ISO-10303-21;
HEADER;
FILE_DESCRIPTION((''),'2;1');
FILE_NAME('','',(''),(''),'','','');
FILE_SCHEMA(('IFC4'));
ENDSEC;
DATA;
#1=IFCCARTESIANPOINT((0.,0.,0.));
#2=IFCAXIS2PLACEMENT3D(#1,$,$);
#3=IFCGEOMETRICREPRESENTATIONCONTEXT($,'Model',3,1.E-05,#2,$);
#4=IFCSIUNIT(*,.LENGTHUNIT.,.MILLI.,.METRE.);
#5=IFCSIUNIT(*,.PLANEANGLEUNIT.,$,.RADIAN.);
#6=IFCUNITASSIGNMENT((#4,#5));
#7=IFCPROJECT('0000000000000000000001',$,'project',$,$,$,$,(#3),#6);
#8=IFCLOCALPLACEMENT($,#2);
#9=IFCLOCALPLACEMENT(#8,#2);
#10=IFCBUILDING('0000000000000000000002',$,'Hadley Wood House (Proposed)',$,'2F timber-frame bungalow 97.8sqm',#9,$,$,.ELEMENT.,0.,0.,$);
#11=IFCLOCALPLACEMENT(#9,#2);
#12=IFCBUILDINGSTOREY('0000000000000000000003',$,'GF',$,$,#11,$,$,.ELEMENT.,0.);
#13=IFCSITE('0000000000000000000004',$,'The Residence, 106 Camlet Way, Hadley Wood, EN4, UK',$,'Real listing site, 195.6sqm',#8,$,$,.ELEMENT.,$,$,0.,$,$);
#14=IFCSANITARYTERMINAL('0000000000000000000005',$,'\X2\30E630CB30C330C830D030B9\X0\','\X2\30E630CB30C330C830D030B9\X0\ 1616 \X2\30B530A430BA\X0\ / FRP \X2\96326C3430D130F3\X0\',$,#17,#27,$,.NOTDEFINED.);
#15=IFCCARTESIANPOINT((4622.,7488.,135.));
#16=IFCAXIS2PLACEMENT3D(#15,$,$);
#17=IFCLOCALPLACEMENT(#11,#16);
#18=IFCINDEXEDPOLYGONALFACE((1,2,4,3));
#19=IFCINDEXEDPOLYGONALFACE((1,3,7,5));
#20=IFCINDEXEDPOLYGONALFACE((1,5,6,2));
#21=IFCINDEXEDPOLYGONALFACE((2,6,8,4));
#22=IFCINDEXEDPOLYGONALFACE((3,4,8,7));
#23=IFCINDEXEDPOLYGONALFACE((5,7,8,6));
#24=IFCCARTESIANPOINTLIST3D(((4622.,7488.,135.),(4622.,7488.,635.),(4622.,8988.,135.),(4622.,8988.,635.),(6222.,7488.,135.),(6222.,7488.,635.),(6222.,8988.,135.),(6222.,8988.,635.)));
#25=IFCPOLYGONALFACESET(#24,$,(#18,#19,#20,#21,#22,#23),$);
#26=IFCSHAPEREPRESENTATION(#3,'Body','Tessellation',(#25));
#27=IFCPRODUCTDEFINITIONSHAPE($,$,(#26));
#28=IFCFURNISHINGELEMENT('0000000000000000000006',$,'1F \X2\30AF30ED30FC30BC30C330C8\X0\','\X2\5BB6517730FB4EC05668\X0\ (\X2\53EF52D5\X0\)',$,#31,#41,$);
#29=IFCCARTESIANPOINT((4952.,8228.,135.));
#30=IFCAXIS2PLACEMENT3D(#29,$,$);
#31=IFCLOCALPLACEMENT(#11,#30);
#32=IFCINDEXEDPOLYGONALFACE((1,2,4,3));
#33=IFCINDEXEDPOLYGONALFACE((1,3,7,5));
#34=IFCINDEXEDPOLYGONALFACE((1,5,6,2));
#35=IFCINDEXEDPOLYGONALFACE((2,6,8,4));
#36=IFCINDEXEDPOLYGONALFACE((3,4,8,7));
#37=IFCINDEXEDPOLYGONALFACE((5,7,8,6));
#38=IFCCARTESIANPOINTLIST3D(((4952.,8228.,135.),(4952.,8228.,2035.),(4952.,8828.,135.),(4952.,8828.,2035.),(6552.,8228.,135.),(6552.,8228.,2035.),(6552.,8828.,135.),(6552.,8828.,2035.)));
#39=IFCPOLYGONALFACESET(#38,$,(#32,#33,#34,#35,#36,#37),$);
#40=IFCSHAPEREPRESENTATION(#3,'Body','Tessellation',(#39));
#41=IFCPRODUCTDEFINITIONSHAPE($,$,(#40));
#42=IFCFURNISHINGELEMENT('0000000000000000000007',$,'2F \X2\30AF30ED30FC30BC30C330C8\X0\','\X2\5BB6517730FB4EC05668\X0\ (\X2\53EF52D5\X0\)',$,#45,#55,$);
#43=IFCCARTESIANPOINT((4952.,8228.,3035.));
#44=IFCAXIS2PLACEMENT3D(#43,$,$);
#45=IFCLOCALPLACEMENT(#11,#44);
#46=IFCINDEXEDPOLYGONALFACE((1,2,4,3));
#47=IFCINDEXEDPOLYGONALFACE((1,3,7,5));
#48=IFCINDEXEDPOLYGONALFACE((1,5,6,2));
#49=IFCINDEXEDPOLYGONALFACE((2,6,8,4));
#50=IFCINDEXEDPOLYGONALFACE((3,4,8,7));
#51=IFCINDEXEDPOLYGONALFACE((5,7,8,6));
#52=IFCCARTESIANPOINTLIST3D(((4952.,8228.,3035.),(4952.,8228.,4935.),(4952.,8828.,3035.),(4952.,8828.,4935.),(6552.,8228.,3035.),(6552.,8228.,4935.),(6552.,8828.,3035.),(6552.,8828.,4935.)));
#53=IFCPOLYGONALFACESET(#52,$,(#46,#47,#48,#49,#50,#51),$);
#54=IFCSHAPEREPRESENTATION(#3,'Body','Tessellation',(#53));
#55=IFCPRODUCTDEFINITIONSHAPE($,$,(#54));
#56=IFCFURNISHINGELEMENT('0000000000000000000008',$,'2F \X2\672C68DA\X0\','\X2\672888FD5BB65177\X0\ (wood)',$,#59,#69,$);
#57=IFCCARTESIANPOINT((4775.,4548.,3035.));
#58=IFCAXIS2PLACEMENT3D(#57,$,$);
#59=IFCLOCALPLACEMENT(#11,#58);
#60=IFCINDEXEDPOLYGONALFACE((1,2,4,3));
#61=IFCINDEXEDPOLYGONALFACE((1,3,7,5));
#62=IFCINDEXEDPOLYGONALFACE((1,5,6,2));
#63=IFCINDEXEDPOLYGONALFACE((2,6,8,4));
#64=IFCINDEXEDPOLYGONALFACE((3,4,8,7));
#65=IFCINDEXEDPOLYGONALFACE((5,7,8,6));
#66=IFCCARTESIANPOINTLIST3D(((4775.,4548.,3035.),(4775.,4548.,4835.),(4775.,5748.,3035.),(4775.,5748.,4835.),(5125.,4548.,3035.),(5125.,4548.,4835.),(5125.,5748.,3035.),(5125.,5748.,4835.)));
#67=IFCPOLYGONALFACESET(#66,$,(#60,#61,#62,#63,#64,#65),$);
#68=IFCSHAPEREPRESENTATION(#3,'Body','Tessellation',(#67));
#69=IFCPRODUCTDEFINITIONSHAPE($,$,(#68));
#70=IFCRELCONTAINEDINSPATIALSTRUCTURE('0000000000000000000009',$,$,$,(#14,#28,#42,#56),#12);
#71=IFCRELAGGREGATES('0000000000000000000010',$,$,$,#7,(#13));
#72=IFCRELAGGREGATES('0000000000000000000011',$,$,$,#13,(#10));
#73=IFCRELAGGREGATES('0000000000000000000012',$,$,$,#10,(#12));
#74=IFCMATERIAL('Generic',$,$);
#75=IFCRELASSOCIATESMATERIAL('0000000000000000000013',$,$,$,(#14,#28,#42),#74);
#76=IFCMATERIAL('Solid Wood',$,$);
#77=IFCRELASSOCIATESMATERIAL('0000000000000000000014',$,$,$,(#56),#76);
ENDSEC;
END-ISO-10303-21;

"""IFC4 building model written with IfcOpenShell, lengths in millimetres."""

from ifc_helpers import new_model, si_unit, frame, frame_2d, origin, place, context, project, spatial, rectangle, extrude, material, element, save


model = new_model("IFC4")

# Units and contexts
model_context = context("Model", 3, precision=1e-05, world=origin())
ifc_project = project(units=[si_unit("LENGTHUNIT", "METRE", prefix="MILLI"), si_unit("PLANEANGLEUNIT", "RADIAN")], contexts=[model_context])

# Site, building, storey
site_placement = place(None, origin())
site = spatial("IfcSite", under=ifc_project, at=site_placement, Name="The Residence, 106 Camlet Way, Hadley Wood, EN4, UK", ObjectType="Real listing site, 195.6sqm", CompositionType="ELEMENT", RefElevation=0.0)
building_placement = place(site_placement, origin())
building = spatial("IfcBuilding", under=site, at=building_placement, Name="Hadley Wood House (Proposed)", ObjectType="2F timber-frame bungalow 97.8sqm", CompositionType="ELEMENT", ElevationOfRefHeight=0.0, ElevationOfTerrain=0.0)
storey_placement = place(building_placement, origin())
storey = spatial("IfcBuildingStorey", under=building, at=storey_placement, Name="GF", CompositionType="ELEMENT", Elevation=0.0)

# Shared definitions
ifc_material_1 = material(Name="Solid Wood")

# Shared definitions
ifc_material_2 = material(Name="Generic")

# Sanitary terminal
sanitary_terminal_placement = place(storey_placement, frame((4622.0, 7488.0, 135.0)))
element("IfcSanitaryTerminal", 1, at=sanitary_terminal_placement, inside=storey, material=ifc_material_2, Name="ユニットバス", Description="ユニットバス 1616 サイズ / FRP 防水パン", PredefinedType="NOTDEFINED", context=model_context, shape_type="SweptSolid", body=[
    extrude(rectangle(XDim=1600.0, YDim=1500.0, at=frame_2d((800.0, 750.0))), frame((4622.0, 7488.0, 135.0)), (0.0, 0.0, 1.0), 500.0),
])

# Furnishing elements
furnishing_1_placement = place(storey_placement, frame((4952.0, 8228.0, 135.0)))
element("IfcFurnishingElement", 2, at=furnishing_1_placement, inside=storey, material=ifc_material_2, Name="1F クローゼット", Description="家具・什器 (可動)", context=model_context, shape_type="SweptSolid", body=[
    extrude(rectangle(XDim=1600.0, YDim=600.0, at=frame_2d((800.0, 300.0))), frame((4952.0, 8228.0, 135.0)), (0.0, 0.0, 1.0), 1900.0),
])
furnishing_2_placement = place(storey_placement, frame((4952.0, 8228.0, 3035.0)))
element("IfcFurnishingElement", 3, at=furnishing_2_placement, inside=storey, material=ifc_material_2, Name="2F クローゼット", Description="家具・什器 (可動)", context=model_context, shape_type="SweptSolid", body=[
    extrude(rectangle(XDim=1600.0, YDim=600.0, at=frame_2d((800.0, 300.0))), frame((4952.0, 8228.0, 3035.0)), (0.0, 0.0, 1.0), 1900.0),
])
furnishing_3_placement = place(storey_placement, frame((4775.0, 4548.0, 3035.0)))
element("IfcFurnishingElement", 4, at=furnishing_3_placement, inside=storey, material=ifc_material_1, Name="2F 本棚", Description="木製家具 (wood)", context=model_context, shape_type="SweptSolid", body=[
    extrude(rectangle(XDim=350.0, YDim=1200.0, at=frame_2d((175.0, 600.0))), frame((4775.0, 4548.0, 3035.0)), (0.0, 0.0, 1.0), 1800.0),
])

save(model, "model.ifc")
